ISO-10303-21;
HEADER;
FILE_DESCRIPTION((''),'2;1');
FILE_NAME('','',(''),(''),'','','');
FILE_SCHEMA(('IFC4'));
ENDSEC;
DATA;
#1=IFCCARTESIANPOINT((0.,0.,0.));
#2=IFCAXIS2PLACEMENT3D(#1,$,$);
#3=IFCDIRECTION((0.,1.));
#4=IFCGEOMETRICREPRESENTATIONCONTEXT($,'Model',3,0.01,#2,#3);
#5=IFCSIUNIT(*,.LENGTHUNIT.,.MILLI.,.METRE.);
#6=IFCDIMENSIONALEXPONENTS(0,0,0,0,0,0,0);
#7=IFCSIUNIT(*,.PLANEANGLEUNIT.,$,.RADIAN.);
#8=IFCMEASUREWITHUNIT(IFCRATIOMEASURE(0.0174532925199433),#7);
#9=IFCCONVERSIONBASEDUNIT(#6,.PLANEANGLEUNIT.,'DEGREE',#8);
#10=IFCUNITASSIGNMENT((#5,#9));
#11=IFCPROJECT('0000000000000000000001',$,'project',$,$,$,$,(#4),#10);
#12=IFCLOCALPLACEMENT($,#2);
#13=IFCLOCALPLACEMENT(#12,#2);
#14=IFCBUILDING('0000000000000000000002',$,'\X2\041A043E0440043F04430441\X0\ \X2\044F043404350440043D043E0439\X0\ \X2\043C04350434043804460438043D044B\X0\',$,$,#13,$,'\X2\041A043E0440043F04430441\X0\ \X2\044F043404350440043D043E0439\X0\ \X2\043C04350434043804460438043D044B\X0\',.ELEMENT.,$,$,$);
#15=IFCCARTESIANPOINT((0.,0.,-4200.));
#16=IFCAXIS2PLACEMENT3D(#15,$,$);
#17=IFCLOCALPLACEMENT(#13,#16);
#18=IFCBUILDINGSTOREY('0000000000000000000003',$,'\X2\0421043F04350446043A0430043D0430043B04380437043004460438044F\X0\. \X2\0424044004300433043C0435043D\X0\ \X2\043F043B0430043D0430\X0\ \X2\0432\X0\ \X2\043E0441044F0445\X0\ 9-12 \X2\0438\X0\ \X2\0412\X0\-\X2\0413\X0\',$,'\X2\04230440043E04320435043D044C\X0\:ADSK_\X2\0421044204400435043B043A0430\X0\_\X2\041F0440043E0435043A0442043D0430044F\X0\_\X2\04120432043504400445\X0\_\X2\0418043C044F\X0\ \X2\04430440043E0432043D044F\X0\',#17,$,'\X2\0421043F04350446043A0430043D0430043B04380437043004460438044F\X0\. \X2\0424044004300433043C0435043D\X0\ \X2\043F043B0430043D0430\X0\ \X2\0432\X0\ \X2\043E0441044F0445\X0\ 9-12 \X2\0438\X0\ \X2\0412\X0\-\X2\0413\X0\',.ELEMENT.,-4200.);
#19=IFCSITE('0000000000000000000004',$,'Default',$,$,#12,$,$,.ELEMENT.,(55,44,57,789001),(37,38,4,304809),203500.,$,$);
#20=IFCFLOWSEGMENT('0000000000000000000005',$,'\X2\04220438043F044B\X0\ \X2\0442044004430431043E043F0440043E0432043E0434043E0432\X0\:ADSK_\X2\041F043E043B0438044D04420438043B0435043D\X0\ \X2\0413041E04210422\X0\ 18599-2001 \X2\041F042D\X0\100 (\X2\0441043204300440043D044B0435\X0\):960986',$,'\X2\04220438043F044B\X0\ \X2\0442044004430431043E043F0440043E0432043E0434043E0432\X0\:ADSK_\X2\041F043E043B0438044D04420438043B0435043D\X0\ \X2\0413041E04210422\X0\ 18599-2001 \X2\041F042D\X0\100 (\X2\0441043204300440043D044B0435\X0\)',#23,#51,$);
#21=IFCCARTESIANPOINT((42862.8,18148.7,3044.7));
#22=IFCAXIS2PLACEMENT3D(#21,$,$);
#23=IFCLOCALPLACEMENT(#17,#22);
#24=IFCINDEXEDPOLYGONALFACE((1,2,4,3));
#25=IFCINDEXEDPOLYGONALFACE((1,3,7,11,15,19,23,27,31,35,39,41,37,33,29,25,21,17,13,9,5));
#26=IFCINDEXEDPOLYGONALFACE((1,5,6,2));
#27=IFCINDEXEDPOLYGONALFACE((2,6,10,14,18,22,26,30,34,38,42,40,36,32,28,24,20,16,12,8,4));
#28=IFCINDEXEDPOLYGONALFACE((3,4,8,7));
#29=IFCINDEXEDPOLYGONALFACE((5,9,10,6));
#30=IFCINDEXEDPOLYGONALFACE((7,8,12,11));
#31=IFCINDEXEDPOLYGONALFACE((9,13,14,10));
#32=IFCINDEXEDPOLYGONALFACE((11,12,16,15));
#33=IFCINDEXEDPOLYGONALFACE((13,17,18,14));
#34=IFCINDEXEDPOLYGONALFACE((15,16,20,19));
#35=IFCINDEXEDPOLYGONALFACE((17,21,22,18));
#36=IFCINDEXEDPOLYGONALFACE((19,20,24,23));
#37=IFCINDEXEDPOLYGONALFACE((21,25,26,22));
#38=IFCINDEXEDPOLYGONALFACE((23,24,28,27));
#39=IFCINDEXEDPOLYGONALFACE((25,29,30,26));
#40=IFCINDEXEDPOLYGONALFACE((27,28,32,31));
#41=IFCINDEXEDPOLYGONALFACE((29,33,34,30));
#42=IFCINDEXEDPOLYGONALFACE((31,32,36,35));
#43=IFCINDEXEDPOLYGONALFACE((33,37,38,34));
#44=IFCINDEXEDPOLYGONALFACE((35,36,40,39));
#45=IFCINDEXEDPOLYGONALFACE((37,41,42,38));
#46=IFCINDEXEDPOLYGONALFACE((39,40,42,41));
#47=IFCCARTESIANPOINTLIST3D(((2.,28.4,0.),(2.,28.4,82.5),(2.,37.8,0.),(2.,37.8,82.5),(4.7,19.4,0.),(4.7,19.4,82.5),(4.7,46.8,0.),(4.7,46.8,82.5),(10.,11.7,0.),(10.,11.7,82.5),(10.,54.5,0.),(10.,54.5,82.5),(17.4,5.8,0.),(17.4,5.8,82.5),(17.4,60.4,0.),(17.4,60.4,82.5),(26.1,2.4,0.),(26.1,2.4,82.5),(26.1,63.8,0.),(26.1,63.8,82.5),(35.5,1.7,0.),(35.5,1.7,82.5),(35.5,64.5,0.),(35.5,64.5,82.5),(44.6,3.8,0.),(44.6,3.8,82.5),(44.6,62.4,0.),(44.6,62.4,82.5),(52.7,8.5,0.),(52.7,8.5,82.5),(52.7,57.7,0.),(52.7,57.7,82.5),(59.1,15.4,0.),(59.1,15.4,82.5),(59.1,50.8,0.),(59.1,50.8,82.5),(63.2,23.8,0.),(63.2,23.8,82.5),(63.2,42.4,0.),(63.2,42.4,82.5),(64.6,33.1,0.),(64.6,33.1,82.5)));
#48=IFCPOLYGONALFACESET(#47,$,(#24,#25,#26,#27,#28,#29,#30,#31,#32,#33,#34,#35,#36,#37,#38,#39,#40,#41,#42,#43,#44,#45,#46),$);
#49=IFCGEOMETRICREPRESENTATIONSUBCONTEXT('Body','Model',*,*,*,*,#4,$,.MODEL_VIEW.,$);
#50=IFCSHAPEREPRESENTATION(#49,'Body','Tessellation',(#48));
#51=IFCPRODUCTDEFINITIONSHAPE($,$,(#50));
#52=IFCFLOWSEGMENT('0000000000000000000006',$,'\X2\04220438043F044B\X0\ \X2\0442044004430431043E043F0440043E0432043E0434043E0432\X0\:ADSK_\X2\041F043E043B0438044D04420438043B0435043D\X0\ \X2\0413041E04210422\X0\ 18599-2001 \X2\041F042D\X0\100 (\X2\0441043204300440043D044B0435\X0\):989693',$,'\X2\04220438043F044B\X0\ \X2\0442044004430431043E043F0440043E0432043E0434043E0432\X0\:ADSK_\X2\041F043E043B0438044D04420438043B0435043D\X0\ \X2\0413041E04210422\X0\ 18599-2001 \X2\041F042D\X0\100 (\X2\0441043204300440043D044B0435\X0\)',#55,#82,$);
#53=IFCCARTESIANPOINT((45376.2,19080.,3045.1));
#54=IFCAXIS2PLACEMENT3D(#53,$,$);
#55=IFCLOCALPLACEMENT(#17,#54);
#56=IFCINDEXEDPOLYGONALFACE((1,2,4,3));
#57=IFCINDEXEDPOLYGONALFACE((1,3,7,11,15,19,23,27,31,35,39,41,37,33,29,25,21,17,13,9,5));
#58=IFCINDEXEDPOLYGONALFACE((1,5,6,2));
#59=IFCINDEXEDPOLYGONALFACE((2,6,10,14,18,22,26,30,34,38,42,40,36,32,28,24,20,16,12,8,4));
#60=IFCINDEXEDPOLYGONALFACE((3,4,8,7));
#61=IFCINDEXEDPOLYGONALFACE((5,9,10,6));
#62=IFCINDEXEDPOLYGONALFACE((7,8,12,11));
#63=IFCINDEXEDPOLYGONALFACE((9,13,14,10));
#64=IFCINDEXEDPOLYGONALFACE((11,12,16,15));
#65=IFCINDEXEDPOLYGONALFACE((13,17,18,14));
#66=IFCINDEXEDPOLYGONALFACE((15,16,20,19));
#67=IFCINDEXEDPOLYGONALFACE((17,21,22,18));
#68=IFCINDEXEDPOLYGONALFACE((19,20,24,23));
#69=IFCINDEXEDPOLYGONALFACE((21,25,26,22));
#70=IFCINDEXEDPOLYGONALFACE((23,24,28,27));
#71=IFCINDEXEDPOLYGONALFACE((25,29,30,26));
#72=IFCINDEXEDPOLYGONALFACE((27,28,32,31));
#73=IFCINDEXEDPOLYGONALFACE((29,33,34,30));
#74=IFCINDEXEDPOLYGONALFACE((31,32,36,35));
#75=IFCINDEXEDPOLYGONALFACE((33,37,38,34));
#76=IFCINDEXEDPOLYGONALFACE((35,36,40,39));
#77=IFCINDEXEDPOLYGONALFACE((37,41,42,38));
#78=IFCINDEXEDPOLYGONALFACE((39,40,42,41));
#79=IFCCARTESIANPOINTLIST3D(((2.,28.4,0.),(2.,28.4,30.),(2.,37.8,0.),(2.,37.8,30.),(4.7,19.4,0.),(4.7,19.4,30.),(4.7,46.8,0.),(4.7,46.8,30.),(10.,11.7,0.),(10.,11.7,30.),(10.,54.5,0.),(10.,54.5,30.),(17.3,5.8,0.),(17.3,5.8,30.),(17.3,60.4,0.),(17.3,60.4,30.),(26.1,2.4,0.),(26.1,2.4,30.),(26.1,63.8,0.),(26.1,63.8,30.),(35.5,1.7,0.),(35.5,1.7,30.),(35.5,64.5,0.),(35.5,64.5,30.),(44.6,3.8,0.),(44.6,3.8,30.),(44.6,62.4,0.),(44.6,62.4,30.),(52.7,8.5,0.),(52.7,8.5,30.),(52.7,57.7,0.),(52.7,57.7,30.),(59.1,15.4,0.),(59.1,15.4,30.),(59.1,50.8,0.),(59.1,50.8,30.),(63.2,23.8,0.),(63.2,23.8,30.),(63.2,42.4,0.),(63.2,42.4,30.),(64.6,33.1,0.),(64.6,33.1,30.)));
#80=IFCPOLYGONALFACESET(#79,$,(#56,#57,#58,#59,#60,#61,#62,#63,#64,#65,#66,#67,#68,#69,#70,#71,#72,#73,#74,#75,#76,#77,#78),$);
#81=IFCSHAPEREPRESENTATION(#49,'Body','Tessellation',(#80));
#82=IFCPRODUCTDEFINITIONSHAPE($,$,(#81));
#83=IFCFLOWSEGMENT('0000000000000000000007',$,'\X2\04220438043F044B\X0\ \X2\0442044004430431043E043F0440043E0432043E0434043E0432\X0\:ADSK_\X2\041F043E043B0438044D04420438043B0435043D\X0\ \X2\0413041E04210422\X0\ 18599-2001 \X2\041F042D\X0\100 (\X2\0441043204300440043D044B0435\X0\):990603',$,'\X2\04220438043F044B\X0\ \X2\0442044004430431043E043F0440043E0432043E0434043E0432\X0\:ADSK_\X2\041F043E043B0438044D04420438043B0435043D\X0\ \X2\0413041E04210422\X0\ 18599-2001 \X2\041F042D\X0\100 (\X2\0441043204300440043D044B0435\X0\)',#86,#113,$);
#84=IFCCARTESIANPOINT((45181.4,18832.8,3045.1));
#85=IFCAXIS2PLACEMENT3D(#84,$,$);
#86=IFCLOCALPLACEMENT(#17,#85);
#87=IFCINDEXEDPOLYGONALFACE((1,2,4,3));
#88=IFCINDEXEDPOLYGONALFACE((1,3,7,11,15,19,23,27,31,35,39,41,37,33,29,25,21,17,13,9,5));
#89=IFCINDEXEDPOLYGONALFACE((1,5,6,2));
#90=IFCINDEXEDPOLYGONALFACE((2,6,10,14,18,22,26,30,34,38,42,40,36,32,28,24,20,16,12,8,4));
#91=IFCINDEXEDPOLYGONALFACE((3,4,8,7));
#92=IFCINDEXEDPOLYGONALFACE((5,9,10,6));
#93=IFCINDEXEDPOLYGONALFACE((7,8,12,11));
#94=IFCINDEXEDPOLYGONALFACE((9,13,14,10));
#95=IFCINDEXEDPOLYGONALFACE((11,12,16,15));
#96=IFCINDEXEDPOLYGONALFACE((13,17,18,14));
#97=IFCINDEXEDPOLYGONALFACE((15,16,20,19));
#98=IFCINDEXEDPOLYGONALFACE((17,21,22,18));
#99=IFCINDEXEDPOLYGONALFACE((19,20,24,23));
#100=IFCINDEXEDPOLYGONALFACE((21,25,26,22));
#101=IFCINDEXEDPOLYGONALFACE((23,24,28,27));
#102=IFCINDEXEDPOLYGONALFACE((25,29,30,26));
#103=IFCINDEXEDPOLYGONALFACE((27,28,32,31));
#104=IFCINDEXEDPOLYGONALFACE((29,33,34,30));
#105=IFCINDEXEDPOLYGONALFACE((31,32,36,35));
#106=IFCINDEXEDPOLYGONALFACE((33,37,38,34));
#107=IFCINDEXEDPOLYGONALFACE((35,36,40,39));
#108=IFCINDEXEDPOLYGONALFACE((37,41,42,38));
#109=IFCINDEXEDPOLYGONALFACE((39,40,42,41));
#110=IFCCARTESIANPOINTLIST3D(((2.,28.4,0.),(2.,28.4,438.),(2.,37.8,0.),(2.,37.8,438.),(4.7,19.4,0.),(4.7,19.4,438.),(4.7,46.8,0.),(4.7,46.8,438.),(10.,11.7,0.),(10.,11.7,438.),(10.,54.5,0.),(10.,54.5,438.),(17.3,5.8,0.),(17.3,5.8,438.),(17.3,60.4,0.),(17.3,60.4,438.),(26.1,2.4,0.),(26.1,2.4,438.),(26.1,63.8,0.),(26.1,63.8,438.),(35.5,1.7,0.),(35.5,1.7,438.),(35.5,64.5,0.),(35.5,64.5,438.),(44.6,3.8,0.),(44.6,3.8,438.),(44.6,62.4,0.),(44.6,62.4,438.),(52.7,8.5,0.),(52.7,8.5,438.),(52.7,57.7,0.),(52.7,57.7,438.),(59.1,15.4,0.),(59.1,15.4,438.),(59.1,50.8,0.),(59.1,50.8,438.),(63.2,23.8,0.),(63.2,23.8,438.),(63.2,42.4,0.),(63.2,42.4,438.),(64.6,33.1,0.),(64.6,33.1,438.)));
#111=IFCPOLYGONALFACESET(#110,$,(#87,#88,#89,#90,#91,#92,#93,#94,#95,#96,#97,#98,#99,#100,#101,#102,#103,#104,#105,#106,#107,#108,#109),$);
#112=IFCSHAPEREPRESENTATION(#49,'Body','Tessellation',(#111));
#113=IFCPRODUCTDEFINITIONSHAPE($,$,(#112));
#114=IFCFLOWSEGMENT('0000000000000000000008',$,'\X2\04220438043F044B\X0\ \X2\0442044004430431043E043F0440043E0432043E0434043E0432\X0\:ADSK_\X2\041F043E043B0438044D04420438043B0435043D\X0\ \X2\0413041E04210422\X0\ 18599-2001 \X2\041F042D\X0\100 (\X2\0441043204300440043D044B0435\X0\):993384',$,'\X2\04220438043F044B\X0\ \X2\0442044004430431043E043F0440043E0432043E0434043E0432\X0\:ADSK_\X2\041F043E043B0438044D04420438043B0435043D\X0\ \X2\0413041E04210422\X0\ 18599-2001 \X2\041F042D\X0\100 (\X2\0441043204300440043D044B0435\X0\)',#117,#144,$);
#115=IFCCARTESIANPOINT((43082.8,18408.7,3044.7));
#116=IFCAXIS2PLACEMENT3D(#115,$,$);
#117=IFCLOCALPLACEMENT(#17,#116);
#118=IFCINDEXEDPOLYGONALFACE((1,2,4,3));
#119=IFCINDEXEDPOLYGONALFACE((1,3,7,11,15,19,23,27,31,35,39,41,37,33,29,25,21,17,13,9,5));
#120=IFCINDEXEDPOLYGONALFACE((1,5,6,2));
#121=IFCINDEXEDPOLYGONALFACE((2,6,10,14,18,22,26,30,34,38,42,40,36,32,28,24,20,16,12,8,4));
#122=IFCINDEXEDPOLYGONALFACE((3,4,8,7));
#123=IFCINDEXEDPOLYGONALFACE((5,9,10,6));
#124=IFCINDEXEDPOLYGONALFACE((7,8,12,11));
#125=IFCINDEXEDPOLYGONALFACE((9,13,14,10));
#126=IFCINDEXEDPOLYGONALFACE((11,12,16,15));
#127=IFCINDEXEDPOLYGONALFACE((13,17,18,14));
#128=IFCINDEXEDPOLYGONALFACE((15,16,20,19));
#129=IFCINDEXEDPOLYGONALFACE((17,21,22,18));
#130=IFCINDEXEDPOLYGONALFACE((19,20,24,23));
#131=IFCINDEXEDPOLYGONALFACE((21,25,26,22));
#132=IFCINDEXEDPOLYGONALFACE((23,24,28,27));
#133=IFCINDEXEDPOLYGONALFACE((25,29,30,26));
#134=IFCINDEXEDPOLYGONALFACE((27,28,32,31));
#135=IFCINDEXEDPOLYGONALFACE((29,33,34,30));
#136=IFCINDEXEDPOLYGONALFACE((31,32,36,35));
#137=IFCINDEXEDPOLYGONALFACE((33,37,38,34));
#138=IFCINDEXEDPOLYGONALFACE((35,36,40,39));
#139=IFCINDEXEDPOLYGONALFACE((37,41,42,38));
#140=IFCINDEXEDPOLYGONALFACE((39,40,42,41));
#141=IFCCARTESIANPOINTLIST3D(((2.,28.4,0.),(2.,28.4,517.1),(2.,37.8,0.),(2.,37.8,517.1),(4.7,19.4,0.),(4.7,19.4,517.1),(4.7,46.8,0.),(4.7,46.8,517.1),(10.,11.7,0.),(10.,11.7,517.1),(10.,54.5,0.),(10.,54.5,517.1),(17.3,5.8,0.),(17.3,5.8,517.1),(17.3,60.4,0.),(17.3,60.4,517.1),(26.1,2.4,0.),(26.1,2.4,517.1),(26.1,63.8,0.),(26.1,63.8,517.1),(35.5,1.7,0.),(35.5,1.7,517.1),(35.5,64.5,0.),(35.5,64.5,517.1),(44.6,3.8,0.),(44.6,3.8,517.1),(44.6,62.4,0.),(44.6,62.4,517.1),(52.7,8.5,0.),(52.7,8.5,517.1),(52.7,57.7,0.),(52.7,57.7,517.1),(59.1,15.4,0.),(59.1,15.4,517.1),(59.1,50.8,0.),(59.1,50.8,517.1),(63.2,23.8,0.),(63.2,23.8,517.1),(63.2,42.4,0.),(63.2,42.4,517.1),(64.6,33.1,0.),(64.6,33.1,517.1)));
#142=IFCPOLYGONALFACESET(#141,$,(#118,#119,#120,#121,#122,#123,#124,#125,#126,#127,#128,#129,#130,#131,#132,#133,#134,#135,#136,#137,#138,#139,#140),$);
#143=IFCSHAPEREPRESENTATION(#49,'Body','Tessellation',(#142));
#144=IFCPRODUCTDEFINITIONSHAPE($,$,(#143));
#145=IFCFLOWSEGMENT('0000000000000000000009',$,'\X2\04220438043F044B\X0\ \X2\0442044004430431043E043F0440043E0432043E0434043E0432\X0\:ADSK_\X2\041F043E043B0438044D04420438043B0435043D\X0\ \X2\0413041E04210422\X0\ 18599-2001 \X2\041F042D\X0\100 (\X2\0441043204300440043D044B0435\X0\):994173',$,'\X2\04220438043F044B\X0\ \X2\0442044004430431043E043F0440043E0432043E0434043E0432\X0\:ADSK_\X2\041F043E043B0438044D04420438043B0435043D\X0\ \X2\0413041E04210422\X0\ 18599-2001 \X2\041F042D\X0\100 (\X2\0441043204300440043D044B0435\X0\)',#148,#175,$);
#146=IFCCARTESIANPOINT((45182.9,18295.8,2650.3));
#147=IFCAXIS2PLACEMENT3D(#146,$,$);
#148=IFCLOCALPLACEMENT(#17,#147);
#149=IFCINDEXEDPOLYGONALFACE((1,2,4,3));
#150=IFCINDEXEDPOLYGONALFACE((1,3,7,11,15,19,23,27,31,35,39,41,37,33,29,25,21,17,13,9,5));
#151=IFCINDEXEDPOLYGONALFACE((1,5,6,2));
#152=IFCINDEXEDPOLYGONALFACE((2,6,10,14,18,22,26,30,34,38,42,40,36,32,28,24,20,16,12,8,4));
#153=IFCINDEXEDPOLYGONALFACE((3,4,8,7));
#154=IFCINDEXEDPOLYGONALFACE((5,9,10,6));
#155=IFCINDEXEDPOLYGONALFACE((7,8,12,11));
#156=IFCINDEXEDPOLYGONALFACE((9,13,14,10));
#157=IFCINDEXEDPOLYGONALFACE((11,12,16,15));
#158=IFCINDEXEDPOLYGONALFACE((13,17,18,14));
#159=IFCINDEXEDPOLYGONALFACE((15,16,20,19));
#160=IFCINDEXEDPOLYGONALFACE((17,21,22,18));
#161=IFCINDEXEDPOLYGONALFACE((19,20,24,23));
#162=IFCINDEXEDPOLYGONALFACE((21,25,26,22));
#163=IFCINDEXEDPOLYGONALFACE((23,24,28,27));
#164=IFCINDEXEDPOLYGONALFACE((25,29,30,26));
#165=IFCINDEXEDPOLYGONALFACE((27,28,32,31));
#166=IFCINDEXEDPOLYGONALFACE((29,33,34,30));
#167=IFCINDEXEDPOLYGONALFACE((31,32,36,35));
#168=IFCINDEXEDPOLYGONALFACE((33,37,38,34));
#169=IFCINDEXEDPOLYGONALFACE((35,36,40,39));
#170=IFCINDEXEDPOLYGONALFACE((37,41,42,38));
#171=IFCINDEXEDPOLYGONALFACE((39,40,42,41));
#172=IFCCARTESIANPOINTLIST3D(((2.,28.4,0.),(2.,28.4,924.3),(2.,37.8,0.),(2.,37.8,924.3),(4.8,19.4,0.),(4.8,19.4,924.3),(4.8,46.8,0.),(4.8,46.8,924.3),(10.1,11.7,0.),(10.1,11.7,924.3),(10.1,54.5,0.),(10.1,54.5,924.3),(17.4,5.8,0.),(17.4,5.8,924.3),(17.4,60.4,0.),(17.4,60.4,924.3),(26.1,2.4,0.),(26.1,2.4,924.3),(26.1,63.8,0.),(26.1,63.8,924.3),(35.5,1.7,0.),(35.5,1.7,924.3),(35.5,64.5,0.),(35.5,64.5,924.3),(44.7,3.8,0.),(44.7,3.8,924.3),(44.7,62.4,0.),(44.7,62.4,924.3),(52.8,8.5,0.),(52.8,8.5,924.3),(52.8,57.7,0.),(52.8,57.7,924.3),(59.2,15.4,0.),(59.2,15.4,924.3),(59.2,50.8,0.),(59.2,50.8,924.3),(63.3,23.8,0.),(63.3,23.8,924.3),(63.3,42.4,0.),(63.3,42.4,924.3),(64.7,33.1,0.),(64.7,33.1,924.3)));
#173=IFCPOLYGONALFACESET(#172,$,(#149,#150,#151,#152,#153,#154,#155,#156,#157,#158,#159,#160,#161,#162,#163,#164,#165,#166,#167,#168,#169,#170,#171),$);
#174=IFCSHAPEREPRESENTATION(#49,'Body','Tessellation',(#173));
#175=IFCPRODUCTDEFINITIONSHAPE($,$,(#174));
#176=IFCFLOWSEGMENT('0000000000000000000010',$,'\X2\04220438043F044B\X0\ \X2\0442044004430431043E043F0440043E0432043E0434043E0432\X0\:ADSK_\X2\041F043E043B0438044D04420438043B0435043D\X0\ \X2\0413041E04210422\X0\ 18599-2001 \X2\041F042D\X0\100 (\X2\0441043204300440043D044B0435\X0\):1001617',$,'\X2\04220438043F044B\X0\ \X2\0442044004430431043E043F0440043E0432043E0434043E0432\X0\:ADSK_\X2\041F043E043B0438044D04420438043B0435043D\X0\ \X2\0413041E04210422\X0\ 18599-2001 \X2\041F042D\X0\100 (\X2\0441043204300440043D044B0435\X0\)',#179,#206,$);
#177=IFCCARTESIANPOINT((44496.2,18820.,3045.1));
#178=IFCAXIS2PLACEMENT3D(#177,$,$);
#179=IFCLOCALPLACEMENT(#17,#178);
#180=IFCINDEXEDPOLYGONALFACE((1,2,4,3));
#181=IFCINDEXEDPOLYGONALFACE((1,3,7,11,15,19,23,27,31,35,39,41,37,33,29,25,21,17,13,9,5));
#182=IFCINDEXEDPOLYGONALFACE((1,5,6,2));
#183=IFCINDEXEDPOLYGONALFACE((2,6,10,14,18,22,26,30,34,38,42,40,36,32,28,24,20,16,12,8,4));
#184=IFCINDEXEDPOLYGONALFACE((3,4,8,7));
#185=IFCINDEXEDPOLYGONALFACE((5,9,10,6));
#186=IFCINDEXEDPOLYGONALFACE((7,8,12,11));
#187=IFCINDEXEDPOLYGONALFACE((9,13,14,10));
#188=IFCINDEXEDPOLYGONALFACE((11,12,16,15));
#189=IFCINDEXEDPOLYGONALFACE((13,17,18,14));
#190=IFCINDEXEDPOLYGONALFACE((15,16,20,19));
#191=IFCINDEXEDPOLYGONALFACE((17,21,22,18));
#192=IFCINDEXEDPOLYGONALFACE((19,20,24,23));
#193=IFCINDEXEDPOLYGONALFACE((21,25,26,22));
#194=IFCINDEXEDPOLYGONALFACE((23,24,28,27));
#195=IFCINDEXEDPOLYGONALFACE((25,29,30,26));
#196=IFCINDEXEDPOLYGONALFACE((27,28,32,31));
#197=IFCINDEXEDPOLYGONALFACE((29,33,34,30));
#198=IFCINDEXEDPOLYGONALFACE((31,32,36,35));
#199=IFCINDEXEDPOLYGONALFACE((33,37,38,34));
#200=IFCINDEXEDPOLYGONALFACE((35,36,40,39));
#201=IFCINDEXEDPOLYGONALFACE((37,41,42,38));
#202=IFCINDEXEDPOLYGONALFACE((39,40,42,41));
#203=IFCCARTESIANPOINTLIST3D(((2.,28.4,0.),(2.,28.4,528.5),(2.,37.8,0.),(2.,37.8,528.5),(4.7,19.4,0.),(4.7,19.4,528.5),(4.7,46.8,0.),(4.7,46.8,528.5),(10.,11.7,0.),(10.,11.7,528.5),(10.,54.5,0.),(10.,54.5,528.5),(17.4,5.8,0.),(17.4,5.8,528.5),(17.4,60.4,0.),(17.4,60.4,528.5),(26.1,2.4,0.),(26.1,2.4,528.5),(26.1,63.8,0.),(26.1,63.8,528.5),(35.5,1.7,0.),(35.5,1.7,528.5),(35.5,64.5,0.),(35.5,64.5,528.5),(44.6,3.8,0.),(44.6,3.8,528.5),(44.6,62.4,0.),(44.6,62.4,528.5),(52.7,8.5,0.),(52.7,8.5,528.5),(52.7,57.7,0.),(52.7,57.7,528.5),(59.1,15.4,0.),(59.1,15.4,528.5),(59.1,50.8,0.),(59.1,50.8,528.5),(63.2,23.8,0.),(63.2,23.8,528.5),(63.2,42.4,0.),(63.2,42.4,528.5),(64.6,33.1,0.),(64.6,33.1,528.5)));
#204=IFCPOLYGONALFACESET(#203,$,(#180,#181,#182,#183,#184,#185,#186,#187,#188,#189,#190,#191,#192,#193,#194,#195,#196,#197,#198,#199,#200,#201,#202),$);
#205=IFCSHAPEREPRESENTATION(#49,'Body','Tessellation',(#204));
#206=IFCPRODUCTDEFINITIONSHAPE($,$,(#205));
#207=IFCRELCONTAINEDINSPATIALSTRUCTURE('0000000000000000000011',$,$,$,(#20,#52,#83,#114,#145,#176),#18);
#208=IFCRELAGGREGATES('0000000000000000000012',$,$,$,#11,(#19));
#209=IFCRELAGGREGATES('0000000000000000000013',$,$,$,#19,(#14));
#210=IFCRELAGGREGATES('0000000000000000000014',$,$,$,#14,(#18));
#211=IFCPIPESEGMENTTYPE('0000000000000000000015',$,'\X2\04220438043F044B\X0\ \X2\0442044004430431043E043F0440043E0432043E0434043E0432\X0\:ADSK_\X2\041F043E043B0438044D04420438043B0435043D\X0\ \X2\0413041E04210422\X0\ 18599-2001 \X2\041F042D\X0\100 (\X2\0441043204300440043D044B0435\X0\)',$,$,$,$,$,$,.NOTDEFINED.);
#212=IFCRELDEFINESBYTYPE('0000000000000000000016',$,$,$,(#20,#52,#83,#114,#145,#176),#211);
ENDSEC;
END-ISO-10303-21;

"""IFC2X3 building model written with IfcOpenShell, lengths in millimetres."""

from ifc_helpers import new_model, entity, si_unit, converted_unit, direction, frame, origin, origin_2d_with_axis, place, context, subcontext, project, spatial, circle, extrude, type_object, element, save


model = new_model("IFC2X3")

# Units and contexts
model_context = context("Model", 3, precision=0.01, world=origin(), true_north=direction((0.0, 1.0)))
body_context = subcontext(model_context, "Body", "Model", "MODEL_VIEW")
ifc_project = project(units=[si_unit("LENGTHUNIT", "METRE", prefix="MILLI"), converted_unit("PLANEANGLEUNIT", "DEGREE", entity("IfcRatioMeasure", 0.0174532925199433), si_unit("PLANEANGLEUNIT", "RADIAN"), dimensions=[0, 0, 0, 0, 0, 0, 0])], contexts=[model_context])

# Site, building, storey
site_placement = place(None, origin())
site = spatial("IfcSite", under=ifc_project, at=site_placement, Name="Default", CompositionType="ELEMENT", RefLatitude=(55, 44, 57, 789001), RefLongitude=(37, 38, 4, 304809), RefElevation=203500.0)
building_placement = place(site_placement, origin())
building = spatial("IfcBuilding", under=site, at=building_placement, Name="Корпус ядерной медицины", LongName="Корпус ядерной медицины", CompositionType="ELEMENT")
storey_placement = place(building_placement, frame((0.0, 0.0, -4200.0)))
storey = spatial("IfcBuildingStorey", under=building, at=storey_placement, Name="Спецканализация. Фрагмен плана в осях 9-12 и В-Г", ObjectType="Уровень:ADSK_Стрелка_Проектная_Вверх_Имя уровня", LongName="Спецканализация. Фрагмен плана в осях 9-12 и В-Г", CompositionType="ELEMENT", Elevation=-4200.0)

# Flow segments
pipe_segment_type = type_object("IfcPipeSegmentType", Name="Типы трубопроводов:ADSK_Полиэтилен ГОСТ 18599-2001 ПЭ100 (сварные)", PredefinedType="NOTDEFINED")
flow_segment_1_placement = place(storey_placement, frame((42862.8, 18148.7, 3044.7)))
element("IfcFlowSegment", 1, at=flow_segment_1_placement, inside=storey, type_object=pipe_segment_type, Name="Типы трубопроводов:ADSK_Полиэтилен ГОСТ 18599-2001 ПЭ100 (сварные):960986", ObjectType="Типы трубопроводов:ADSK_Полиэтилен ГОСТ 18599-2001 ПЭ100 (сварные)", context=body_context, shape_type="SweptSolid", body=[
    extrude(circle(Radius=31.5, at=origin_2d_with_axis()), frame((33.1, 33.1, 0.0)), (0.0, 0.0, 1.0), 82.5),
])
flow_segment_2_placement = place(storey_placement, frame((45376.2, 19080.0, 3045.1)))
element("IfcFlowSegment", 2, at=flow_segment_2_placement, inside=storey, type_object=pipe_segment_type, Name="Типы трубопроводов:ADSK_Полиэтилен ГОСТ 18599-2001 ПЭ100 (сварные):989693", ObjectType="Типы трубопроводов:ADSK_Полиэтилен ГОСТ 18599-2001 ПЭ100 (сварные)", context=body_context, shape_type="SweptSolid", body=[
    extrude(circle(Radius=31.5, at=origin_2d_with_axis()), frame((33.1, 33.1, 0.0)), (0.0, 0.0, 1.0), 30.0),
])
flow_segment_3_placement = place(storey_placement, frame((45181.4, 18832.8, 3045.1)))
element("IfcFlowSegment", 3, at=flow_segment_3_placement, inside=storey, type_object=pipe_segment_type, Name="Типы трубопроводов:ADSK_Полиэтилен ГОСТ 18599-2001 ПЭ100 (сварные):990603", ObjectType="Типы трубопроводов:ADSK_Полиэтилен ГОСТ 18599-2001 ПЭ100 (сварные)", context=body_context, shape_type="SweptSolid", body=[
    extrude(circle(Radius=31.5, at=origin_2d_with_axis()), frame((33.1, 33.1, 0.0)), (0.0, 0.0, 1.0), 438.0),
])
flow_segment_4_placement = place(storey_placement, frame((43082.8, 18408.7, 3044.7)))
element("IfcFlowSegment", 4, at=flow_segment_4_placement, inside=storey, type_object=pipe_segment_type, Name="Типы трубопроводов:ADSK_Полиэтилен ГОСТ 18599-2001 ПЭ100 (сварные):993384", ObjectType="Типы трубопроводов:ADSK_Полиэтилен ГОСТ 18599-2001 ПЭ100 (сварные)", context=body_context, shape_type="SweptSolid", body=[
    extrude(circle(Radius=31.5, at=origin_2d_with_axis()), frame((33.1, 33.1, 0.0)), (0.0, 0.0, 1.0), 517.1),
])
flow_segment_5_placement = place(storey_placement, frame((45182.9, 18295.8, 2650.3)))
element("IfcFlowSegment", 5, at=flow_segment_5_placement, inside=storey, type_object=pipe_segment_type, Name="Типы трубопроводов:ADSK_Полиэтилен ГОСТ 18599-2001 ПЭ100 (сварные):994173", ObjectType="Типы трубопроводов:ADSK_Полиэтилен ГОСТ 18599-2001 ПЭ100 (сварные)", context=body_context, shape_type="SweptSolid", body=[
    extrude(circle(Radius=31.5, at=origin_2d_with_axis()), frame((33.1, 33.1, 0.0)), (0.0, 0.0, 1.0), 924.3),
])
flow_segment_6_placement = place(storey_placement, frame((44496.2, 18820.0, 3045.1)))
element("IfcFlowSegment", 6, at=flow_segment_6_placement, inside=storey, type_object=pipe_segment_type, Name="Типы трубопроводов:ADSK_Полиэтилен ГОСТ 18599-2001 ПЭ100 (сварные):1001617", ObjectType="Типы трубопроводов:ADSK_Полиэтилен ГОСТ 18599-2001 ПЭ100 (сварные)", context=body_context, shape_type="SweptSolid", body=[
    extrude(circle(Radius=31.5, at=origin_2d_with_axis()), frame((33.1, 33.1, 0.0)), (0.0, 0.0, 1.0), 528.5),
])

save(model, "model.ifc")
